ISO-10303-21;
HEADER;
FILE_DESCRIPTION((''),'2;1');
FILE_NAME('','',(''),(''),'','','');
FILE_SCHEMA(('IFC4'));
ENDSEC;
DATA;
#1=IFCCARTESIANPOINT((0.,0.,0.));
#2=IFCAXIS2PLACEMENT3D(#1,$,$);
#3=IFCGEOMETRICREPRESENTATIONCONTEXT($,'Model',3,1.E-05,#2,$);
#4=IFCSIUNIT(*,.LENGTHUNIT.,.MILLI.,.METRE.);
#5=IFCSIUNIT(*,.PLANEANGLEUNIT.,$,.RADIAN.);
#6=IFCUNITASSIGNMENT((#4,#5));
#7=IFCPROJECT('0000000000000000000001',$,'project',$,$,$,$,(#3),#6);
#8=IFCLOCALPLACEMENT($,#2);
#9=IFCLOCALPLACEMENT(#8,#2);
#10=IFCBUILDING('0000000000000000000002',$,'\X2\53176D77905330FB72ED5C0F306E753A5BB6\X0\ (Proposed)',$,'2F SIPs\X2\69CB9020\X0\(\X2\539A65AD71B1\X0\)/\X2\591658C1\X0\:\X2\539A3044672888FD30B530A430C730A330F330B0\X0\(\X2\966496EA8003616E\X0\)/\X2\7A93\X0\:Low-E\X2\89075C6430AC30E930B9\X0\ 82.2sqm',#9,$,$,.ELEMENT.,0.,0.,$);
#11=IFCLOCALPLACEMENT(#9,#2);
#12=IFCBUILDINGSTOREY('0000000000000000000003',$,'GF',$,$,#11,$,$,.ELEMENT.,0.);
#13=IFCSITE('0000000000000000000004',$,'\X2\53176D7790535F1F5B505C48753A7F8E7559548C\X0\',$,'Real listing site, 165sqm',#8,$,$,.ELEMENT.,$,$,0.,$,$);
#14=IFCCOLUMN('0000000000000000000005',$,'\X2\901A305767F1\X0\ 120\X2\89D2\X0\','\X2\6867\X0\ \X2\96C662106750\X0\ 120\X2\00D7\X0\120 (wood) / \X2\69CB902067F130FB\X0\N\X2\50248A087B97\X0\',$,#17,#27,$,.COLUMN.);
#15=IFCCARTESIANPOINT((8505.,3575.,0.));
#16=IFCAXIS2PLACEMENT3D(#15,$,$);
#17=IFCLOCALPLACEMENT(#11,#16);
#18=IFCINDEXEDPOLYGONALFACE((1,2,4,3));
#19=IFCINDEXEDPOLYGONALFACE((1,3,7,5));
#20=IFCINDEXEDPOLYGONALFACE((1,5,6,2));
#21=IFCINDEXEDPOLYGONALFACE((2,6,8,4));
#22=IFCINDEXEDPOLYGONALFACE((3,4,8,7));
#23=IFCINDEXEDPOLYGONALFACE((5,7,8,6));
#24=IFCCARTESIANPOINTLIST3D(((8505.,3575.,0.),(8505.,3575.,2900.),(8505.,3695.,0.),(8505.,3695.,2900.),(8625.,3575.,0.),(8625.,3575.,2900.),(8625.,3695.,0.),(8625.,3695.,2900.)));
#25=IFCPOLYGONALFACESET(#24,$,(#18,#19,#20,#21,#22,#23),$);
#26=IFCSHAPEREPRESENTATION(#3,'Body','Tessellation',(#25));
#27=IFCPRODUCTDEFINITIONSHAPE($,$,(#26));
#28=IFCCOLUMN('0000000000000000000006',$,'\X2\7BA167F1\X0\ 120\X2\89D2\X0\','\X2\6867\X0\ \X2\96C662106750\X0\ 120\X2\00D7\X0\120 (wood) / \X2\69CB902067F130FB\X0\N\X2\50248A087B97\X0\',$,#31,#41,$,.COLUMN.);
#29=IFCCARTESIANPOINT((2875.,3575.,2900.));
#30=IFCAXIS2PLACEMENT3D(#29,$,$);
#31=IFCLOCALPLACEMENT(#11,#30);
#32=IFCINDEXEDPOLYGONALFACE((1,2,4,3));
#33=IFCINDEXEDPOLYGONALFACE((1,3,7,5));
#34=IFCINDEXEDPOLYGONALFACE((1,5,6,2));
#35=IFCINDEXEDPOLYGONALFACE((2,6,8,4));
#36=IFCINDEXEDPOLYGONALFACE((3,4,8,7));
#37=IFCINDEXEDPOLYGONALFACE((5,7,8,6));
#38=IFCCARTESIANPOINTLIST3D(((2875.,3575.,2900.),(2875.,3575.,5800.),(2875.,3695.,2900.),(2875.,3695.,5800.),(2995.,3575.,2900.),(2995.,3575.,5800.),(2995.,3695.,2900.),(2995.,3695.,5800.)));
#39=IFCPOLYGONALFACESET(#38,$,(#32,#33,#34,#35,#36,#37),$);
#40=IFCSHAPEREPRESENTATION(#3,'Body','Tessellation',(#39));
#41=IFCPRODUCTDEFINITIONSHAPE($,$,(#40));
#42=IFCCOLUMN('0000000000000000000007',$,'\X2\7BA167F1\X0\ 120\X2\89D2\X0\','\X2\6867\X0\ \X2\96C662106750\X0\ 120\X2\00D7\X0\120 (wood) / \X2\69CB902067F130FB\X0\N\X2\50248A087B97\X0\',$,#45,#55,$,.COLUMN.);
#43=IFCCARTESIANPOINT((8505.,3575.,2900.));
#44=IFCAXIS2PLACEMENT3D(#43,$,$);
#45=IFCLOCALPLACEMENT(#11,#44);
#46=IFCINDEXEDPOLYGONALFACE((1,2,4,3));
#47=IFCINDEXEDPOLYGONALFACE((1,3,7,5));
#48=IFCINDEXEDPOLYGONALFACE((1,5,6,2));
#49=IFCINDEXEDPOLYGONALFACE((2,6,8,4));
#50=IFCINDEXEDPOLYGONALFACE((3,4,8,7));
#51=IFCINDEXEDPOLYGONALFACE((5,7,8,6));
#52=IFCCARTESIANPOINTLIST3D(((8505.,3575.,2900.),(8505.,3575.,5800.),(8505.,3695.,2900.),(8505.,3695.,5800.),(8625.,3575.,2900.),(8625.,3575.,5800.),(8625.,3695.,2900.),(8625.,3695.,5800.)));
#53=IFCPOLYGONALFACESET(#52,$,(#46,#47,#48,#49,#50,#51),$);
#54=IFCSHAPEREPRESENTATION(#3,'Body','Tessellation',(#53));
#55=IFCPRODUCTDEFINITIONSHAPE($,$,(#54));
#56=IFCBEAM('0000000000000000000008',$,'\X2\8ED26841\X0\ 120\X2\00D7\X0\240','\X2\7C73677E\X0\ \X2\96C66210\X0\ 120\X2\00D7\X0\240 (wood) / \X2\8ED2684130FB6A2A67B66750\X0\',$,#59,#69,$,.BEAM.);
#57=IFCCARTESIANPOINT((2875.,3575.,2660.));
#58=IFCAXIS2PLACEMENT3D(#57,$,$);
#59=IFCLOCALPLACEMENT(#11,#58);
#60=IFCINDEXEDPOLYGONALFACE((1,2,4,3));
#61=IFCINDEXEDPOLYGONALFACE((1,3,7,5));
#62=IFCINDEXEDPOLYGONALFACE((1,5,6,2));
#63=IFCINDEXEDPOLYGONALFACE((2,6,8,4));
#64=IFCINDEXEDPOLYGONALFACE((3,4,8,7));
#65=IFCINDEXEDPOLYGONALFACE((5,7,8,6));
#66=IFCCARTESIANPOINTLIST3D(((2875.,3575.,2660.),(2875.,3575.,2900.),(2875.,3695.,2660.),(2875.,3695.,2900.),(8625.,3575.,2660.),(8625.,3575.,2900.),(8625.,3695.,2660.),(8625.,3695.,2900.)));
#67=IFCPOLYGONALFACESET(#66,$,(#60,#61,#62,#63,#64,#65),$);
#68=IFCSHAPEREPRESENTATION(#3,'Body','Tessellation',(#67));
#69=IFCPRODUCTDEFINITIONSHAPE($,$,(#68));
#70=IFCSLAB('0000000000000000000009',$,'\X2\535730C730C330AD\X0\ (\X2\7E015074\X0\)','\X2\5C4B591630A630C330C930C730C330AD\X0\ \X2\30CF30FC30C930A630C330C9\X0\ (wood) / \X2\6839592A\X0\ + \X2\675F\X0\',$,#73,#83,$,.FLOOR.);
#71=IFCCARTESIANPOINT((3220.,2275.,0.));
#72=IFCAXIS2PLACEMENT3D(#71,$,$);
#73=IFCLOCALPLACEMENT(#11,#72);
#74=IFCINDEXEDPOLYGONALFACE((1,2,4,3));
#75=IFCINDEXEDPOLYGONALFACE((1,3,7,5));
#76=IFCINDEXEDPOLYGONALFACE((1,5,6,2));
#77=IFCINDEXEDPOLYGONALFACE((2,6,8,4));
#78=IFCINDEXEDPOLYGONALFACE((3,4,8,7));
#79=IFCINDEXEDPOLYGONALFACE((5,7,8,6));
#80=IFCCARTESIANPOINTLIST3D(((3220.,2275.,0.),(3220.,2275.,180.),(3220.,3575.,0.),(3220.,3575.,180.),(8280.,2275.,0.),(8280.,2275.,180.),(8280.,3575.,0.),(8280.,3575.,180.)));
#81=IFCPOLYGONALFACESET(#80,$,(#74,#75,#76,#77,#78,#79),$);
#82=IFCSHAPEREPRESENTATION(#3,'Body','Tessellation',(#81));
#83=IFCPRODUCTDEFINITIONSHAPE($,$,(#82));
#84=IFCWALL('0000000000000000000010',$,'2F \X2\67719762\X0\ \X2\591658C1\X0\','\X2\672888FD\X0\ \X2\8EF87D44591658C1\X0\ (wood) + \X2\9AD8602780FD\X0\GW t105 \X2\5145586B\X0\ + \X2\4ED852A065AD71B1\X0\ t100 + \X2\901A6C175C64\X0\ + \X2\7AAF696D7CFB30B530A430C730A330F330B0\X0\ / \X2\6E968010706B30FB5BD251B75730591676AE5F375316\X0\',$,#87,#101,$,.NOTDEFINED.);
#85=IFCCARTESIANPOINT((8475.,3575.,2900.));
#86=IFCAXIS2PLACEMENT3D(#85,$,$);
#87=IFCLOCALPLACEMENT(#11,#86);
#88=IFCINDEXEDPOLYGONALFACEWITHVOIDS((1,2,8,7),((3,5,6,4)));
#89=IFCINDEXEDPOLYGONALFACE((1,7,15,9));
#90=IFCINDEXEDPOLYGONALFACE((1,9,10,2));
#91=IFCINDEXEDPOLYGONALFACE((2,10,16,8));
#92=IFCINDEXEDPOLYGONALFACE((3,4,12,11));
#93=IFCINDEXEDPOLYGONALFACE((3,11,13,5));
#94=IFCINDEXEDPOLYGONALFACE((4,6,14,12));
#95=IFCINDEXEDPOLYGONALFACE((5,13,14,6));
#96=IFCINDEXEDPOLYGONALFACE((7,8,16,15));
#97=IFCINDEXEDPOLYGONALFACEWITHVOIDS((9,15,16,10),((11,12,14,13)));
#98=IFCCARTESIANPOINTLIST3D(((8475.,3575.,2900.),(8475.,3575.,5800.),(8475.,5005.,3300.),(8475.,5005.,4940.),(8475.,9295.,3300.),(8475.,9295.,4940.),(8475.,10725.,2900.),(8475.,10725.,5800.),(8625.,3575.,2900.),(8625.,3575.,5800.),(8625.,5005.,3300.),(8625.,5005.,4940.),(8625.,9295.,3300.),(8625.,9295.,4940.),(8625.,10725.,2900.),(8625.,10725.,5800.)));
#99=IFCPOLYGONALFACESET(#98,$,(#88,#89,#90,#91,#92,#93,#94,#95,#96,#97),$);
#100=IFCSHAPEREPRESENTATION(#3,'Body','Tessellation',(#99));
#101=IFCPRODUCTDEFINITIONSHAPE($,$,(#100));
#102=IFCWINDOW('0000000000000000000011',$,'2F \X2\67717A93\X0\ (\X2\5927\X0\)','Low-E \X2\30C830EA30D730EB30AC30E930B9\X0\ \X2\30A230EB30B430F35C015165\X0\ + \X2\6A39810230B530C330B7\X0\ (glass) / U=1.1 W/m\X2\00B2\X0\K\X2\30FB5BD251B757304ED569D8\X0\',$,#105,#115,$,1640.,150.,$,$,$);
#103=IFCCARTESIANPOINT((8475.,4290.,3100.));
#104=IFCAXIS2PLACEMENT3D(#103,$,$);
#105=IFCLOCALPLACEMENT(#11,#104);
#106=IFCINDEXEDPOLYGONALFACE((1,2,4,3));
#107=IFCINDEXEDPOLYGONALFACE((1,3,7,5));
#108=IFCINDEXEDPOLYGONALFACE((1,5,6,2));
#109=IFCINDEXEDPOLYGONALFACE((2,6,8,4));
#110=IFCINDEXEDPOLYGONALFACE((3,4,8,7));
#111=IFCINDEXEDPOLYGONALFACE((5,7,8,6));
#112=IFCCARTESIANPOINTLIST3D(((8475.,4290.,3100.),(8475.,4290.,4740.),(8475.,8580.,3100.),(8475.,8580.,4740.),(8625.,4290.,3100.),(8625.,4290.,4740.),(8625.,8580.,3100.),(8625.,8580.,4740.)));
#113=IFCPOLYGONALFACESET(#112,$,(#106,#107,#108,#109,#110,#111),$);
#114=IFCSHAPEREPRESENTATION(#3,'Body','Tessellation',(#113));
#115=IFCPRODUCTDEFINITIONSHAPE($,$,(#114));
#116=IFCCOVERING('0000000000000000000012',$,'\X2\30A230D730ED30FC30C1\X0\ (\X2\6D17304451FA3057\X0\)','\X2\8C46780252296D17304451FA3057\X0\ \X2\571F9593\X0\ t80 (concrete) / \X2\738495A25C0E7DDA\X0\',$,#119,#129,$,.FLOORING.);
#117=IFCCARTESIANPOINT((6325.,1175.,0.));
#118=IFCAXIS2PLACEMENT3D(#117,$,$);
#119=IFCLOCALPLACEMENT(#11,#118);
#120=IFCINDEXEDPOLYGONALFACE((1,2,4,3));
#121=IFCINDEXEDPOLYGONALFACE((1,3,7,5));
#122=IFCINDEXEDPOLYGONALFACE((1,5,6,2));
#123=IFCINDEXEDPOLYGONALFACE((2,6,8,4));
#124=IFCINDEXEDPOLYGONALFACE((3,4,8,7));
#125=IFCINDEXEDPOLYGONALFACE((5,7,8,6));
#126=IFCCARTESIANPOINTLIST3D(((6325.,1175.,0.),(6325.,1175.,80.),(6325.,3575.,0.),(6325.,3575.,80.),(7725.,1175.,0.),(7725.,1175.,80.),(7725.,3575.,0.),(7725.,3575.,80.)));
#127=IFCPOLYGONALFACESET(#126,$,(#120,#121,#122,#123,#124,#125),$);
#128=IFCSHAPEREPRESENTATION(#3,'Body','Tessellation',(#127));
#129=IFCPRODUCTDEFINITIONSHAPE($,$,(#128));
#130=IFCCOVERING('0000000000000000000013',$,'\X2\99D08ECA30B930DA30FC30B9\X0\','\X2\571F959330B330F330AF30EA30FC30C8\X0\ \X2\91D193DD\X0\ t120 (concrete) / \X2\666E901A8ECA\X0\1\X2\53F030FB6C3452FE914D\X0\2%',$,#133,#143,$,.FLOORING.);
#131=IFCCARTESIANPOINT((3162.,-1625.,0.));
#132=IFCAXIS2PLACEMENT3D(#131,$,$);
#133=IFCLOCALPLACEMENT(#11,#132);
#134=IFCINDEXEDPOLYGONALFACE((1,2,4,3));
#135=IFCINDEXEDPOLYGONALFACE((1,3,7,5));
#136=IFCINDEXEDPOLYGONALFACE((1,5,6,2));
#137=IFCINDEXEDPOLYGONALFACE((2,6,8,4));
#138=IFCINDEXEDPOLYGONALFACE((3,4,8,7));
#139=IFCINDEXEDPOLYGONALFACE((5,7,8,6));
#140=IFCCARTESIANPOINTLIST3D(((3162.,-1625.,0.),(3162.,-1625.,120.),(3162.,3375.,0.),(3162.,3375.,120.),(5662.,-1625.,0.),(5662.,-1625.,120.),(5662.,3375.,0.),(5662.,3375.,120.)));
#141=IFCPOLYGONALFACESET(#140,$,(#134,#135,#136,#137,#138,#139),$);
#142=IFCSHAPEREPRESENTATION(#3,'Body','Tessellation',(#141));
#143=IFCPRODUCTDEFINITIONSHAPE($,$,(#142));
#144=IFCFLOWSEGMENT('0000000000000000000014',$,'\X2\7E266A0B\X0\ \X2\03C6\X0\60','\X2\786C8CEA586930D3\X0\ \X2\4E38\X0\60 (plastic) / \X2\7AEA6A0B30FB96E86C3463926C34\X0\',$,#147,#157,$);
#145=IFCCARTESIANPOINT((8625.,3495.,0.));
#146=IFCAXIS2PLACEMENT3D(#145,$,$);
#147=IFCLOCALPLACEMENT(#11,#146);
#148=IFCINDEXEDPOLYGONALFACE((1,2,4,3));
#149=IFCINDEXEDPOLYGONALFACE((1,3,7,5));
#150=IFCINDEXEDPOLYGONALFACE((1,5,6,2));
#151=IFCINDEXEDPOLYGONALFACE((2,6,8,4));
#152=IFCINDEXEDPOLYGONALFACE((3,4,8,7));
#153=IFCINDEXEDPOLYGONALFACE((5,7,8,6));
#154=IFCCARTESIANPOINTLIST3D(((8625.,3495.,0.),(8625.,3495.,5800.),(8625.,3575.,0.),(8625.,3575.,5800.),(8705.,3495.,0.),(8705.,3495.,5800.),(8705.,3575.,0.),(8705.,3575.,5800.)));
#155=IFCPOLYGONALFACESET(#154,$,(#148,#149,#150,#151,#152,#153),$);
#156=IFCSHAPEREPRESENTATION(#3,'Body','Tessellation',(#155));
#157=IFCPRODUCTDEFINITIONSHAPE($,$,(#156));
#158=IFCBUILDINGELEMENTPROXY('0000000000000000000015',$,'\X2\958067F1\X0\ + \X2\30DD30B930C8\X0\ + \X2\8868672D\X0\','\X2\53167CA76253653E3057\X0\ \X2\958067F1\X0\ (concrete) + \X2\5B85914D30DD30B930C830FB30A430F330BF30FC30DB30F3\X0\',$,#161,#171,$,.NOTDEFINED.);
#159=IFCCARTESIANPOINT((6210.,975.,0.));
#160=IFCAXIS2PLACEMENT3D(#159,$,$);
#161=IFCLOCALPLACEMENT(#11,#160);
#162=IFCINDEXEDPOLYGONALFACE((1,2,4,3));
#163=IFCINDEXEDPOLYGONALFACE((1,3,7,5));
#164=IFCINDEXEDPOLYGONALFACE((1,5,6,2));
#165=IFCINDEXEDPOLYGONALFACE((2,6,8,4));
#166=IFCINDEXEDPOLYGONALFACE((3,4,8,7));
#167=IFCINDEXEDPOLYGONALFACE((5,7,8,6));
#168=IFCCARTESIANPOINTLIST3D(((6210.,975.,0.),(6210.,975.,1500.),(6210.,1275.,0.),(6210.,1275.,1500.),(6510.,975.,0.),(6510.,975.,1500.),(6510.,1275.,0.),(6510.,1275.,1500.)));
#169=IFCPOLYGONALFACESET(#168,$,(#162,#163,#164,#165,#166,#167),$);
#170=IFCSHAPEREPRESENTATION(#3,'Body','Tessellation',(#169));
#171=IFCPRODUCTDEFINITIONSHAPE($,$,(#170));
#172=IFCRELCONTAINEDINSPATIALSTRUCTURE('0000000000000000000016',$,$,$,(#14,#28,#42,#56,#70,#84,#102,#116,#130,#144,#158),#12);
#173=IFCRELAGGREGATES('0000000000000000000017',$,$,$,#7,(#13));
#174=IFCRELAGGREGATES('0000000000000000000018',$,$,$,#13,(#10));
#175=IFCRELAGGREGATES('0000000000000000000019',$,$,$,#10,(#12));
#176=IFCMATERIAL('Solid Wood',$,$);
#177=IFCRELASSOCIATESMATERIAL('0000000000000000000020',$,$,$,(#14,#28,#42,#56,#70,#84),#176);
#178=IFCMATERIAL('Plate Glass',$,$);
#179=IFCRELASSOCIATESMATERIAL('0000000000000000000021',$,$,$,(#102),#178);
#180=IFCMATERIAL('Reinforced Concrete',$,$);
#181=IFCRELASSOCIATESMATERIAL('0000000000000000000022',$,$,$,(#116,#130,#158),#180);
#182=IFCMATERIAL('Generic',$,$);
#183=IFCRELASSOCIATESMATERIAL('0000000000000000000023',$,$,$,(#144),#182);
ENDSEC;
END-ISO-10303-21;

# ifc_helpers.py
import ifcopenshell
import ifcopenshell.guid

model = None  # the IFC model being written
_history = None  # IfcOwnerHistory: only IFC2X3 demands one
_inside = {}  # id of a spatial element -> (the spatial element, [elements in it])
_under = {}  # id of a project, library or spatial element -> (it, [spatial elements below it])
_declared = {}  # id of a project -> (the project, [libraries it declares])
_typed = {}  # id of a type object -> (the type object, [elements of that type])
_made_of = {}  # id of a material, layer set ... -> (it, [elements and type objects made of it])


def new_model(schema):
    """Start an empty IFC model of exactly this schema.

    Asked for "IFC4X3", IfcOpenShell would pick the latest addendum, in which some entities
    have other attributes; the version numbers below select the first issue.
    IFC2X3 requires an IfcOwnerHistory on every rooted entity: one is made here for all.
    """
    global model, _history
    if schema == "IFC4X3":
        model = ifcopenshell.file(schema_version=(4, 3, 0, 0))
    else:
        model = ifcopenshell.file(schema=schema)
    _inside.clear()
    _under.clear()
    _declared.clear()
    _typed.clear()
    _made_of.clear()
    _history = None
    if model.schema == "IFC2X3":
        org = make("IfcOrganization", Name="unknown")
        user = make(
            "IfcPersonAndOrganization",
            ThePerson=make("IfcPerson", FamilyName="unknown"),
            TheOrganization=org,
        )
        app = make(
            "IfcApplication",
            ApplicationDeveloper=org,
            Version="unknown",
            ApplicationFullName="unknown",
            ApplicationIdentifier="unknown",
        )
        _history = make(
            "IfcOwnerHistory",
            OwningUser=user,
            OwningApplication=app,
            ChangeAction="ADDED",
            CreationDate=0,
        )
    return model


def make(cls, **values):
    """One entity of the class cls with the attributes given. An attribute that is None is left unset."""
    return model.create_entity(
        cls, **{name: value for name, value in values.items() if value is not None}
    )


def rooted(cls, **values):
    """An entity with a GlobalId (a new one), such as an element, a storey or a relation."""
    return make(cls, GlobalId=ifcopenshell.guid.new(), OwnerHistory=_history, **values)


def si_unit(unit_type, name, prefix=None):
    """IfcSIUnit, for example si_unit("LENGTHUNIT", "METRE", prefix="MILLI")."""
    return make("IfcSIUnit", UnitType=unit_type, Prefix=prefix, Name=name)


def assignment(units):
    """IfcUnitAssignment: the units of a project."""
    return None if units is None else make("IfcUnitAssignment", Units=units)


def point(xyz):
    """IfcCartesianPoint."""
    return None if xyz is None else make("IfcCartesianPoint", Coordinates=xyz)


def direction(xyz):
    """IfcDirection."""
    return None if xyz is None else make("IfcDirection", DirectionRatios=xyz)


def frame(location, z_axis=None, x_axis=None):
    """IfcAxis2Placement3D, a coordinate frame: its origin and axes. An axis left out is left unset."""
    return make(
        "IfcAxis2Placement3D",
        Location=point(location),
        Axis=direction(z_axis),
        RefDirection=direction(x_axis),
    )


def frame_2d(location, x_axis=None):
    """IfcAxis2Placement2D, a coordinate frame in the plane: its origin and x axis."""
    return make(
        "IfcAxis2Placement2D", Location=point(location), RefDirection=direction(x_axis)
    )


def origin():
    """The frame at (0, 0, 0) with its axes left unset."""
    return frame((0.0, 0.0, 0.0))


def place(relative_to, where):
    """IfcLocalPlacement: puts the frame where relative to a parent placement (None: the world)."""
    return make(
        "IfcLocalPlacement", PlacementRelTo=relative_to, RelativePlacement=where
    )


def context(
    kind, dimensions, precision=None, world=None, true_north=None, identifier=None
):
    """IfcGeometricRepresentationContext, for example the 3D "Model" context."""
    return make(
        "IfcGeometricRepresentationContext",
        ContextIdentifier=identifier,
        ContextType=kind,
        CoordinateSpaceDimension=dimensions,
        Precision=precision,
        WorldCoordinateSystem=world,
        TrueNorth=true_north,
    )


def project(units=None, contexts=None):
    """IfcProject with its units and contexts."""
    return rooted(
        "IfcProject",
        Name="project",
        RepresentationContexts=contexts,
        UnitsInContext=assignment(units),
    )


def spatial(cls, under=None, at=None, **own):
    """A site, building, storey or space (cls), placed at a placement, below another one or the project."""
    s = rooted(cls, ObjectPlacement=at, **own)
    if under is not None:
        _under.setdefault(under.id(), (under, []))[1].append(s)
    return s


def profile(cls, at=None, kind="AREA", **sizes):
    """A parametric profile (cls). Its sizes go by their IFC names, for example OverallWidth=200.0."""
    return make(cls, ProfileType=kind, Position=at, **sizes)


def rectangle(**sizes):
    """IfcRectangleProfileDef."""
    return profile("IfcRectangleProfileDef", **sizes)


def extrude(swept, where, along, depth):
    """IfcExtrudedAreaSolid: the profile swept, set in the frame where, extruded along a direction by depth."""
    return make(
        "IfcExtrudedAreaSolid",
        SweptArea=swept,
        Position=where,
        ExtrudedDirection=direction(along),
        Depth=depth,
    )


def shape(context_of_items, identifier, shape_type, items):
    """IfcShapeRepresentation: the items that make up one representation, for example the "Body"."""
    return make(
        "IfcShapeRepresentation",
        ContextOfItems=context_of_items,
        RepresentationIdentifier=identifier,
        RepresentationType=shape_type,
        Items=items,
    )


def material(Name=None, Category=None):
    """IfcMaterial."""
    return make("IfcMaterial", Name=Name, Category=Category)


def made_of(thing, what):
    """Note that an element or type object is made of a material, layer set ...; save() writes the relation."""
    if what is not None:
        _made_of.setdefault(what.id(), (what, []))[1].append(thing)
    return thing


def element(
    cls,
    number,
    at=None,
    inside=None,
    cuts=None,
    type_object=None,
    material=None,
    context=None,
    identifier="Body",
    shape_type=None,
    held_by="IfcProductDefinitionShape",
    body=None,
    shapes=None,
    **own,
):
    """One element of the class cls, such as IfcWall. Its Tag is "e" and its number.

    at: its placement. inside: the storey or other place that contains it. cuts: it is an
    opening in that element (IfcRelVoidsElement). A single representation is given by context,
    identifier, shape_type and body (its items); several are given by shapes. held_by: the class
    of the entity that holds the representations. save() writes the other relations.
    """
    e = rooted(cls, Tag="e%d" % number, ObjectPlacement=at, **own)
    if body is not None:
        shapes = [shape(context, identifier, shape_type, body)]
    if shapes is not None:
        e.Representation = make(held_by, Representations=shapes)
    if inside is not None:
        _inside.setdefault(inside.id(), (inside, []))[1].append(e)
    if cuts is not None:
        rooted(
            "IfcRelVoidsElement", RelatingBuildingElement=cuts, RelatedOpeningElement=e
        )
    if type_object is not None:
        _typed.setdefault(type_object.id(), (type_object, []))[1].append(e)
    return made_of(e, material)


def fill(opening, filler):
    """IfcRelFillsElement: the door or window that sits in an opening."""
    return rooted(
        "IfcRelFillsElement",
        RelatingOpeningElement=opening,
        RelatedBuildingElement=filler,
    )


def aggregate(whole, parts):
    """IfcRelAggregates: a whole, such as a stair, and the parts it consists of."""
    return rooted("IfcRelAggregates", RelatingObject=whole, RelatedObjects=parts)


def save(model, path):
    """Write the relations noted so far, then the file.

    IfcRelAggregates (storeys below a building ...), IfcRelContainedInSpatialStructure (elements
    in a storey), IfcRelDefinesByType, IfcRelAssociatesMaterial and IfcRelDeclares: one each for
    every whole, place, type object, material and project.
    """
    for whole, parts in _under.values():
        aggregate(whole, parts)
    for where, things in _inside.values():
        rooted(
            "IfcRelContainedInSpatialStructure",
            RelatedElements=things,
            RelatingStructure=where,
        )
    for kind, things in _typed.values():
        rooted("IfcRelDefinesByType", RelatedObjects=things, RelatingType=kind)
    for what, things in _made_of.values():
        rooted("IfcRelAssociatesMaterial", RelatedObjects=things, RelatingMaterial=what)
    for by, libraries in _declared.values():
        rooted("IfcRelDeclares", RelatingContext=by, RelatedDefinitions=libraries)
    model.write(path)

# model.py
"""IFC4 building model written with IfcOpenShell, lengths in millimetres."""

from ifc_helpers import new_model, si_unit, frame, frame_2d, origin, place, context, project, spatial, rectangle, extrude, material, element, fill, save


model = new_model("IFC4")

# Units and contexts
model_context = context("Model", 3, precision=1e-05, world=origin())
ifc_project = project(units=[si_unit("LENGTHUNIT", "METRE", prefix="MILLI"), si_unit("PLANEANGLEUNIT", "RADIAN")], contexts=[model_context])

# Site, building, storey
site_placement = place(None, origin())
site = spatial("IfcSite", under=ifc_project, at=site_placement, Name="北海道弟子屈町美留和", ObjectType="Real listing site, 165sqm", CompositionType="ELEMENT", RefElevation=0.0)
building_placement = place(site_placement, origin())
building = spatial("IfcBuilding", under=site, at=building_placement, Name="北海道・狭小の町家 (Proposed)", ObjectType="2F SIPs構造(厚断熱)/外壁:厚い木製サイディング(除雪考慮)/窓:Low-E複層ガラス 82.2sqm", CompositionType="ELEMENT", ElevationOfRefHeight=0.0, ElevationOfTerrain=0.0)
storey_placement = place(building_placement, origin())
storey = spatial("IfcBuildingStorey", under=building, at=storey_placement, Name="GF", CompositionType="ELEMENT", Elevation=0.0)

# Columns
ifc_material_1 = material(Name="Solid Wood")
column_1_placement = place(storey_placement, frame((8505.0, 3575.0, 0.0)))
element("IfcColumn", 1, at=column_1_placement, inside=storey, material=ifc_material_1, Name="通し柱 120角", Description="桧 集成材 120×120 (wood) / 構造柱・N値計算", PredefinedType="COLUMN", context=model_context, shape_type="SweptSolid", body=[
    extrude(rectangle(XDim=120.0, YDim=120.0, at=frame_2d((60.0, 60.0))), frame((8505.0, 3575.0, 0.0)), (0.0, 0.0, 1.0), 2900.0),
])
column_2_placement = place(storey_placement, frame((2875.0, 3575.0, 2900.0)))
element("IfcColumn", 2, at=column_2_placement, inside=storey, material=ifc_material_1, Name="管柱 120角", Description="桧 集成材 120×120 (wood) / 構造柱・N値計算", PredefinedType="COLUMN", context=model_context, shape_type="SweptSolid", body=[
    extrude(rectangle(XDim=120.0, YDim=120.0, at=frame_2d((60.0, 60.0))), frame((2875.0, 3575.0, 2900.0)), (0.0, 0.0, 1.0), 2900.0),
])
column_3_placement = place(storey_placement, frame((8505.0, 3575.0, 2900.0)))
element("IfcColumn", 3, at=column_3_placement, inside=storey, material=ifc_material_1, Name="管柱 120角", Description="桧 集成材 120×120 (wood) / 構造柱・N値計算", PredefinedType="COLUMN", context=model_context, shape_type="SweptSolid", body=[
    extrude(rectangle(XDim=120.0, YDim=120.0, at=frame_2d((60.0, 60.0))), frame((8505.0, 3575.0, 2900.0)), (0.0, 0.0, 1.0), 2900.0),
])

# Beam
beam_1_placement = place(storey_placement, frame((2875.0, 3575.0, 2660.0)))
element("IfcBeam", 4, at=beam_1_placement, inside=storey, material=ifc_material_1, Name="軒桁 120×240", Description="米松 集成 120×240 (wood) / 軒桁・横架材", PredefinedType="BEAM", context=model_context, shape_type="SweptSolid", body=[
    extrude(rectangle(XDim=5750.0, YDim=120.0, at=frame_2d((2875.0, 60.0))), frame((2875.0, 3575.0, 2660.0)), (0.0, 0.0, 1.0), 240.0),
])

# Slab
slab_placement = place(storey_placement, frame((3220.0, 2275.0, 0.0)))
element("IfcSlab", 5, at=slab_placement, inside=storey, material=ifc_material_1, Name="南デッキ (縁側)", Description="屋外ウッドデッキ ハードウッド (wood) / 根太 + 束", PredefinedType="FLOOR", context=model_context, shape_type="SweptSolid", body=[
    extrude(rectangle(XDim=5060.0, YDim=1300.0, at=frame_2d((2530.0, 650.0))), frame((3220.0, 2275.0, 0.0)), (0.0, 0.0, 1.0), 180.0),
])

# Wall, opening, window
ifc_material_2 = material(Name="Plate Glass")
wall_1_placement = place(storey_placement, frame((8475.0, 3575.0, 2900.0)))
wall_1 = element("IfcWall", 6, at=wall_1_placement, inside=storey, material=ifc_material_1, Name="2F 東面 外壁", Description="木製 軸組外壁 (wood) + 高性能GW t105 充填 + 付加断熱 t100 + 通気層 + 窯業系サイディング / 準耐火・寒冷地外皮強化", PredefinedType="NOTDEFINED", context=model_context, shape_type="SweptSolid", body=[
    extrude(rectangle(XDim=150.0, YDim=7150.0, at=frame_2d((75.0, 3575.0))), frame((8475.0, 3575.0, 2900.0)), (0.0, 0.0, 1.0), 2900.0),
])
opening_1_placement = place(storey_placement, frame((8475.0, 4290.0, 3100.0)))
opening_1 = element("IfcOpeningElement", 7, at=opening_1_placement, cuts=wall_1, PredefinedType="NOTDEFINED", context=model_context, shape_type="SweptSolid", body=[
    extrude(rectangle(XDim=150.0, YDim=4290.0, at=frame_2d((75.0, 2145.0))), frame((8475.0, 4290.0, 3100.0)), (0.0, 0.0, 1.0), 1640.0),
])
window_1_placement = place(storey_placement, frame((8475.0, 4290.0, 3100.0)))
window_1 = element("IfcWindow", 8, at=window_1_placement, inside=storey, material=ifc_material_2, Name="2F 東窓 (大)", Description="Low-E トリプルガラス アルゴン封入 + 樹脂サッシ (glass) / U=1.1 W/m²K・寒冷地仕様", OverallHeight=1640.0, OverallWidth=150.0, context=model_context, shape_type="SweptSolid", body=[
    extrude(rectangle(XDim=150.0, YDim=4290.0, at=frame_2d((75.0, 2145.0))), frame((8475.0, 4290.0, 3100.0)), (0.0, 0.0, 1.0), 1640.0),
])
fill(opening_1, window_1)

# Coverings
ifc_material_3 = material(Name="Reinforced Concrete")
covering_1_placement = place(storey_placement, frame((6325.0, 1175.0, 0.0)))
element("IfcCovering", 9, at=covering_1_placement, inside=storey, material=ifc_material_3, Name="アプローチ (洗い出し)", Description="豆砂利洗い出し 土間 t80 (concrete) / 玄関導線", PredefinedType="FLOORING", context=model_context, shape_type="SweptSolid", body=[
    extrude(rectangle(XDim=1400.0, YDim=2400.0, at=frame_2d((700.0, 1200.0))), frame((6325.0, 1175.0, 0.0)), (0.0, 0.0, 1.0), 80.0),
])
covering_2_placement = place(storey_placement, frame((3162.0, -1625.0, 0.0)))
element("IfcCovering", 10, at=covering_2_placement, inside=storey, material=ifc_material_3, Name="駐車スペース", Description="土間コンクリート 金鏝 t120 (concrete) / 普通車1台・水勾配2%", PredefinedType="FLOORING", context=model_context, shape_type="SweptSolid", body=[
    extrude(rectangle(XDim=2500.0, YDim=5000.0, at=frame_2d((1250.0, 2500.0))), frame((3162.0, -1625.0, 0.0)), (0.0, 0.0, 1.0), 120.0),
])

# Flow segment
ifc_material_4 = material(Name="Generic")
flow_segment_placement = place(storey_placement, frame((8625.0, 3495.0, 0.0)))
element("IfcFlowSegment", 11, at=flow_segment_placement, inside=storey, material=ifc_material_4, Name="縦樋 φ60", Description="硬質塩ビ 丸60 (plastic) / 竪樋・雨水排水", context=model_context, shape_type="SweptSolid", body=[
    extrude(rectangle(XDim=80.0, YDim=80.0, at=frame_2d((40.0, 40.0))), frame((8625.0, 3495.0, 0.0)), (0.0, 0.0, 1.0), 5800.0),
])

# Building element proxy
proxy_placement = place(storey_placement, frame((6210.0, 975.0, 0.0)))
element("IfcBuildingElementProxy", 12, at=proxy_placement, inside=storey, material=ifc_material_3, Name="門柱 + ポスト + 表札", Description="化粧打放し 門柱 (concrete) + 宅配ポスト・インターホン", PredefinedType="NOTDEFINED", context=model_context, shape_type="SweptSolid", body=[
    extrude(rectangle(XDim=300.0, YDim=300.0, at=frame_2d((150.0, 150.0))), frame((6210.0, 975.0, 0.0)), (0.0, 0.0, 1.0), 1500.0),
])

save(model, "model.ifc")
